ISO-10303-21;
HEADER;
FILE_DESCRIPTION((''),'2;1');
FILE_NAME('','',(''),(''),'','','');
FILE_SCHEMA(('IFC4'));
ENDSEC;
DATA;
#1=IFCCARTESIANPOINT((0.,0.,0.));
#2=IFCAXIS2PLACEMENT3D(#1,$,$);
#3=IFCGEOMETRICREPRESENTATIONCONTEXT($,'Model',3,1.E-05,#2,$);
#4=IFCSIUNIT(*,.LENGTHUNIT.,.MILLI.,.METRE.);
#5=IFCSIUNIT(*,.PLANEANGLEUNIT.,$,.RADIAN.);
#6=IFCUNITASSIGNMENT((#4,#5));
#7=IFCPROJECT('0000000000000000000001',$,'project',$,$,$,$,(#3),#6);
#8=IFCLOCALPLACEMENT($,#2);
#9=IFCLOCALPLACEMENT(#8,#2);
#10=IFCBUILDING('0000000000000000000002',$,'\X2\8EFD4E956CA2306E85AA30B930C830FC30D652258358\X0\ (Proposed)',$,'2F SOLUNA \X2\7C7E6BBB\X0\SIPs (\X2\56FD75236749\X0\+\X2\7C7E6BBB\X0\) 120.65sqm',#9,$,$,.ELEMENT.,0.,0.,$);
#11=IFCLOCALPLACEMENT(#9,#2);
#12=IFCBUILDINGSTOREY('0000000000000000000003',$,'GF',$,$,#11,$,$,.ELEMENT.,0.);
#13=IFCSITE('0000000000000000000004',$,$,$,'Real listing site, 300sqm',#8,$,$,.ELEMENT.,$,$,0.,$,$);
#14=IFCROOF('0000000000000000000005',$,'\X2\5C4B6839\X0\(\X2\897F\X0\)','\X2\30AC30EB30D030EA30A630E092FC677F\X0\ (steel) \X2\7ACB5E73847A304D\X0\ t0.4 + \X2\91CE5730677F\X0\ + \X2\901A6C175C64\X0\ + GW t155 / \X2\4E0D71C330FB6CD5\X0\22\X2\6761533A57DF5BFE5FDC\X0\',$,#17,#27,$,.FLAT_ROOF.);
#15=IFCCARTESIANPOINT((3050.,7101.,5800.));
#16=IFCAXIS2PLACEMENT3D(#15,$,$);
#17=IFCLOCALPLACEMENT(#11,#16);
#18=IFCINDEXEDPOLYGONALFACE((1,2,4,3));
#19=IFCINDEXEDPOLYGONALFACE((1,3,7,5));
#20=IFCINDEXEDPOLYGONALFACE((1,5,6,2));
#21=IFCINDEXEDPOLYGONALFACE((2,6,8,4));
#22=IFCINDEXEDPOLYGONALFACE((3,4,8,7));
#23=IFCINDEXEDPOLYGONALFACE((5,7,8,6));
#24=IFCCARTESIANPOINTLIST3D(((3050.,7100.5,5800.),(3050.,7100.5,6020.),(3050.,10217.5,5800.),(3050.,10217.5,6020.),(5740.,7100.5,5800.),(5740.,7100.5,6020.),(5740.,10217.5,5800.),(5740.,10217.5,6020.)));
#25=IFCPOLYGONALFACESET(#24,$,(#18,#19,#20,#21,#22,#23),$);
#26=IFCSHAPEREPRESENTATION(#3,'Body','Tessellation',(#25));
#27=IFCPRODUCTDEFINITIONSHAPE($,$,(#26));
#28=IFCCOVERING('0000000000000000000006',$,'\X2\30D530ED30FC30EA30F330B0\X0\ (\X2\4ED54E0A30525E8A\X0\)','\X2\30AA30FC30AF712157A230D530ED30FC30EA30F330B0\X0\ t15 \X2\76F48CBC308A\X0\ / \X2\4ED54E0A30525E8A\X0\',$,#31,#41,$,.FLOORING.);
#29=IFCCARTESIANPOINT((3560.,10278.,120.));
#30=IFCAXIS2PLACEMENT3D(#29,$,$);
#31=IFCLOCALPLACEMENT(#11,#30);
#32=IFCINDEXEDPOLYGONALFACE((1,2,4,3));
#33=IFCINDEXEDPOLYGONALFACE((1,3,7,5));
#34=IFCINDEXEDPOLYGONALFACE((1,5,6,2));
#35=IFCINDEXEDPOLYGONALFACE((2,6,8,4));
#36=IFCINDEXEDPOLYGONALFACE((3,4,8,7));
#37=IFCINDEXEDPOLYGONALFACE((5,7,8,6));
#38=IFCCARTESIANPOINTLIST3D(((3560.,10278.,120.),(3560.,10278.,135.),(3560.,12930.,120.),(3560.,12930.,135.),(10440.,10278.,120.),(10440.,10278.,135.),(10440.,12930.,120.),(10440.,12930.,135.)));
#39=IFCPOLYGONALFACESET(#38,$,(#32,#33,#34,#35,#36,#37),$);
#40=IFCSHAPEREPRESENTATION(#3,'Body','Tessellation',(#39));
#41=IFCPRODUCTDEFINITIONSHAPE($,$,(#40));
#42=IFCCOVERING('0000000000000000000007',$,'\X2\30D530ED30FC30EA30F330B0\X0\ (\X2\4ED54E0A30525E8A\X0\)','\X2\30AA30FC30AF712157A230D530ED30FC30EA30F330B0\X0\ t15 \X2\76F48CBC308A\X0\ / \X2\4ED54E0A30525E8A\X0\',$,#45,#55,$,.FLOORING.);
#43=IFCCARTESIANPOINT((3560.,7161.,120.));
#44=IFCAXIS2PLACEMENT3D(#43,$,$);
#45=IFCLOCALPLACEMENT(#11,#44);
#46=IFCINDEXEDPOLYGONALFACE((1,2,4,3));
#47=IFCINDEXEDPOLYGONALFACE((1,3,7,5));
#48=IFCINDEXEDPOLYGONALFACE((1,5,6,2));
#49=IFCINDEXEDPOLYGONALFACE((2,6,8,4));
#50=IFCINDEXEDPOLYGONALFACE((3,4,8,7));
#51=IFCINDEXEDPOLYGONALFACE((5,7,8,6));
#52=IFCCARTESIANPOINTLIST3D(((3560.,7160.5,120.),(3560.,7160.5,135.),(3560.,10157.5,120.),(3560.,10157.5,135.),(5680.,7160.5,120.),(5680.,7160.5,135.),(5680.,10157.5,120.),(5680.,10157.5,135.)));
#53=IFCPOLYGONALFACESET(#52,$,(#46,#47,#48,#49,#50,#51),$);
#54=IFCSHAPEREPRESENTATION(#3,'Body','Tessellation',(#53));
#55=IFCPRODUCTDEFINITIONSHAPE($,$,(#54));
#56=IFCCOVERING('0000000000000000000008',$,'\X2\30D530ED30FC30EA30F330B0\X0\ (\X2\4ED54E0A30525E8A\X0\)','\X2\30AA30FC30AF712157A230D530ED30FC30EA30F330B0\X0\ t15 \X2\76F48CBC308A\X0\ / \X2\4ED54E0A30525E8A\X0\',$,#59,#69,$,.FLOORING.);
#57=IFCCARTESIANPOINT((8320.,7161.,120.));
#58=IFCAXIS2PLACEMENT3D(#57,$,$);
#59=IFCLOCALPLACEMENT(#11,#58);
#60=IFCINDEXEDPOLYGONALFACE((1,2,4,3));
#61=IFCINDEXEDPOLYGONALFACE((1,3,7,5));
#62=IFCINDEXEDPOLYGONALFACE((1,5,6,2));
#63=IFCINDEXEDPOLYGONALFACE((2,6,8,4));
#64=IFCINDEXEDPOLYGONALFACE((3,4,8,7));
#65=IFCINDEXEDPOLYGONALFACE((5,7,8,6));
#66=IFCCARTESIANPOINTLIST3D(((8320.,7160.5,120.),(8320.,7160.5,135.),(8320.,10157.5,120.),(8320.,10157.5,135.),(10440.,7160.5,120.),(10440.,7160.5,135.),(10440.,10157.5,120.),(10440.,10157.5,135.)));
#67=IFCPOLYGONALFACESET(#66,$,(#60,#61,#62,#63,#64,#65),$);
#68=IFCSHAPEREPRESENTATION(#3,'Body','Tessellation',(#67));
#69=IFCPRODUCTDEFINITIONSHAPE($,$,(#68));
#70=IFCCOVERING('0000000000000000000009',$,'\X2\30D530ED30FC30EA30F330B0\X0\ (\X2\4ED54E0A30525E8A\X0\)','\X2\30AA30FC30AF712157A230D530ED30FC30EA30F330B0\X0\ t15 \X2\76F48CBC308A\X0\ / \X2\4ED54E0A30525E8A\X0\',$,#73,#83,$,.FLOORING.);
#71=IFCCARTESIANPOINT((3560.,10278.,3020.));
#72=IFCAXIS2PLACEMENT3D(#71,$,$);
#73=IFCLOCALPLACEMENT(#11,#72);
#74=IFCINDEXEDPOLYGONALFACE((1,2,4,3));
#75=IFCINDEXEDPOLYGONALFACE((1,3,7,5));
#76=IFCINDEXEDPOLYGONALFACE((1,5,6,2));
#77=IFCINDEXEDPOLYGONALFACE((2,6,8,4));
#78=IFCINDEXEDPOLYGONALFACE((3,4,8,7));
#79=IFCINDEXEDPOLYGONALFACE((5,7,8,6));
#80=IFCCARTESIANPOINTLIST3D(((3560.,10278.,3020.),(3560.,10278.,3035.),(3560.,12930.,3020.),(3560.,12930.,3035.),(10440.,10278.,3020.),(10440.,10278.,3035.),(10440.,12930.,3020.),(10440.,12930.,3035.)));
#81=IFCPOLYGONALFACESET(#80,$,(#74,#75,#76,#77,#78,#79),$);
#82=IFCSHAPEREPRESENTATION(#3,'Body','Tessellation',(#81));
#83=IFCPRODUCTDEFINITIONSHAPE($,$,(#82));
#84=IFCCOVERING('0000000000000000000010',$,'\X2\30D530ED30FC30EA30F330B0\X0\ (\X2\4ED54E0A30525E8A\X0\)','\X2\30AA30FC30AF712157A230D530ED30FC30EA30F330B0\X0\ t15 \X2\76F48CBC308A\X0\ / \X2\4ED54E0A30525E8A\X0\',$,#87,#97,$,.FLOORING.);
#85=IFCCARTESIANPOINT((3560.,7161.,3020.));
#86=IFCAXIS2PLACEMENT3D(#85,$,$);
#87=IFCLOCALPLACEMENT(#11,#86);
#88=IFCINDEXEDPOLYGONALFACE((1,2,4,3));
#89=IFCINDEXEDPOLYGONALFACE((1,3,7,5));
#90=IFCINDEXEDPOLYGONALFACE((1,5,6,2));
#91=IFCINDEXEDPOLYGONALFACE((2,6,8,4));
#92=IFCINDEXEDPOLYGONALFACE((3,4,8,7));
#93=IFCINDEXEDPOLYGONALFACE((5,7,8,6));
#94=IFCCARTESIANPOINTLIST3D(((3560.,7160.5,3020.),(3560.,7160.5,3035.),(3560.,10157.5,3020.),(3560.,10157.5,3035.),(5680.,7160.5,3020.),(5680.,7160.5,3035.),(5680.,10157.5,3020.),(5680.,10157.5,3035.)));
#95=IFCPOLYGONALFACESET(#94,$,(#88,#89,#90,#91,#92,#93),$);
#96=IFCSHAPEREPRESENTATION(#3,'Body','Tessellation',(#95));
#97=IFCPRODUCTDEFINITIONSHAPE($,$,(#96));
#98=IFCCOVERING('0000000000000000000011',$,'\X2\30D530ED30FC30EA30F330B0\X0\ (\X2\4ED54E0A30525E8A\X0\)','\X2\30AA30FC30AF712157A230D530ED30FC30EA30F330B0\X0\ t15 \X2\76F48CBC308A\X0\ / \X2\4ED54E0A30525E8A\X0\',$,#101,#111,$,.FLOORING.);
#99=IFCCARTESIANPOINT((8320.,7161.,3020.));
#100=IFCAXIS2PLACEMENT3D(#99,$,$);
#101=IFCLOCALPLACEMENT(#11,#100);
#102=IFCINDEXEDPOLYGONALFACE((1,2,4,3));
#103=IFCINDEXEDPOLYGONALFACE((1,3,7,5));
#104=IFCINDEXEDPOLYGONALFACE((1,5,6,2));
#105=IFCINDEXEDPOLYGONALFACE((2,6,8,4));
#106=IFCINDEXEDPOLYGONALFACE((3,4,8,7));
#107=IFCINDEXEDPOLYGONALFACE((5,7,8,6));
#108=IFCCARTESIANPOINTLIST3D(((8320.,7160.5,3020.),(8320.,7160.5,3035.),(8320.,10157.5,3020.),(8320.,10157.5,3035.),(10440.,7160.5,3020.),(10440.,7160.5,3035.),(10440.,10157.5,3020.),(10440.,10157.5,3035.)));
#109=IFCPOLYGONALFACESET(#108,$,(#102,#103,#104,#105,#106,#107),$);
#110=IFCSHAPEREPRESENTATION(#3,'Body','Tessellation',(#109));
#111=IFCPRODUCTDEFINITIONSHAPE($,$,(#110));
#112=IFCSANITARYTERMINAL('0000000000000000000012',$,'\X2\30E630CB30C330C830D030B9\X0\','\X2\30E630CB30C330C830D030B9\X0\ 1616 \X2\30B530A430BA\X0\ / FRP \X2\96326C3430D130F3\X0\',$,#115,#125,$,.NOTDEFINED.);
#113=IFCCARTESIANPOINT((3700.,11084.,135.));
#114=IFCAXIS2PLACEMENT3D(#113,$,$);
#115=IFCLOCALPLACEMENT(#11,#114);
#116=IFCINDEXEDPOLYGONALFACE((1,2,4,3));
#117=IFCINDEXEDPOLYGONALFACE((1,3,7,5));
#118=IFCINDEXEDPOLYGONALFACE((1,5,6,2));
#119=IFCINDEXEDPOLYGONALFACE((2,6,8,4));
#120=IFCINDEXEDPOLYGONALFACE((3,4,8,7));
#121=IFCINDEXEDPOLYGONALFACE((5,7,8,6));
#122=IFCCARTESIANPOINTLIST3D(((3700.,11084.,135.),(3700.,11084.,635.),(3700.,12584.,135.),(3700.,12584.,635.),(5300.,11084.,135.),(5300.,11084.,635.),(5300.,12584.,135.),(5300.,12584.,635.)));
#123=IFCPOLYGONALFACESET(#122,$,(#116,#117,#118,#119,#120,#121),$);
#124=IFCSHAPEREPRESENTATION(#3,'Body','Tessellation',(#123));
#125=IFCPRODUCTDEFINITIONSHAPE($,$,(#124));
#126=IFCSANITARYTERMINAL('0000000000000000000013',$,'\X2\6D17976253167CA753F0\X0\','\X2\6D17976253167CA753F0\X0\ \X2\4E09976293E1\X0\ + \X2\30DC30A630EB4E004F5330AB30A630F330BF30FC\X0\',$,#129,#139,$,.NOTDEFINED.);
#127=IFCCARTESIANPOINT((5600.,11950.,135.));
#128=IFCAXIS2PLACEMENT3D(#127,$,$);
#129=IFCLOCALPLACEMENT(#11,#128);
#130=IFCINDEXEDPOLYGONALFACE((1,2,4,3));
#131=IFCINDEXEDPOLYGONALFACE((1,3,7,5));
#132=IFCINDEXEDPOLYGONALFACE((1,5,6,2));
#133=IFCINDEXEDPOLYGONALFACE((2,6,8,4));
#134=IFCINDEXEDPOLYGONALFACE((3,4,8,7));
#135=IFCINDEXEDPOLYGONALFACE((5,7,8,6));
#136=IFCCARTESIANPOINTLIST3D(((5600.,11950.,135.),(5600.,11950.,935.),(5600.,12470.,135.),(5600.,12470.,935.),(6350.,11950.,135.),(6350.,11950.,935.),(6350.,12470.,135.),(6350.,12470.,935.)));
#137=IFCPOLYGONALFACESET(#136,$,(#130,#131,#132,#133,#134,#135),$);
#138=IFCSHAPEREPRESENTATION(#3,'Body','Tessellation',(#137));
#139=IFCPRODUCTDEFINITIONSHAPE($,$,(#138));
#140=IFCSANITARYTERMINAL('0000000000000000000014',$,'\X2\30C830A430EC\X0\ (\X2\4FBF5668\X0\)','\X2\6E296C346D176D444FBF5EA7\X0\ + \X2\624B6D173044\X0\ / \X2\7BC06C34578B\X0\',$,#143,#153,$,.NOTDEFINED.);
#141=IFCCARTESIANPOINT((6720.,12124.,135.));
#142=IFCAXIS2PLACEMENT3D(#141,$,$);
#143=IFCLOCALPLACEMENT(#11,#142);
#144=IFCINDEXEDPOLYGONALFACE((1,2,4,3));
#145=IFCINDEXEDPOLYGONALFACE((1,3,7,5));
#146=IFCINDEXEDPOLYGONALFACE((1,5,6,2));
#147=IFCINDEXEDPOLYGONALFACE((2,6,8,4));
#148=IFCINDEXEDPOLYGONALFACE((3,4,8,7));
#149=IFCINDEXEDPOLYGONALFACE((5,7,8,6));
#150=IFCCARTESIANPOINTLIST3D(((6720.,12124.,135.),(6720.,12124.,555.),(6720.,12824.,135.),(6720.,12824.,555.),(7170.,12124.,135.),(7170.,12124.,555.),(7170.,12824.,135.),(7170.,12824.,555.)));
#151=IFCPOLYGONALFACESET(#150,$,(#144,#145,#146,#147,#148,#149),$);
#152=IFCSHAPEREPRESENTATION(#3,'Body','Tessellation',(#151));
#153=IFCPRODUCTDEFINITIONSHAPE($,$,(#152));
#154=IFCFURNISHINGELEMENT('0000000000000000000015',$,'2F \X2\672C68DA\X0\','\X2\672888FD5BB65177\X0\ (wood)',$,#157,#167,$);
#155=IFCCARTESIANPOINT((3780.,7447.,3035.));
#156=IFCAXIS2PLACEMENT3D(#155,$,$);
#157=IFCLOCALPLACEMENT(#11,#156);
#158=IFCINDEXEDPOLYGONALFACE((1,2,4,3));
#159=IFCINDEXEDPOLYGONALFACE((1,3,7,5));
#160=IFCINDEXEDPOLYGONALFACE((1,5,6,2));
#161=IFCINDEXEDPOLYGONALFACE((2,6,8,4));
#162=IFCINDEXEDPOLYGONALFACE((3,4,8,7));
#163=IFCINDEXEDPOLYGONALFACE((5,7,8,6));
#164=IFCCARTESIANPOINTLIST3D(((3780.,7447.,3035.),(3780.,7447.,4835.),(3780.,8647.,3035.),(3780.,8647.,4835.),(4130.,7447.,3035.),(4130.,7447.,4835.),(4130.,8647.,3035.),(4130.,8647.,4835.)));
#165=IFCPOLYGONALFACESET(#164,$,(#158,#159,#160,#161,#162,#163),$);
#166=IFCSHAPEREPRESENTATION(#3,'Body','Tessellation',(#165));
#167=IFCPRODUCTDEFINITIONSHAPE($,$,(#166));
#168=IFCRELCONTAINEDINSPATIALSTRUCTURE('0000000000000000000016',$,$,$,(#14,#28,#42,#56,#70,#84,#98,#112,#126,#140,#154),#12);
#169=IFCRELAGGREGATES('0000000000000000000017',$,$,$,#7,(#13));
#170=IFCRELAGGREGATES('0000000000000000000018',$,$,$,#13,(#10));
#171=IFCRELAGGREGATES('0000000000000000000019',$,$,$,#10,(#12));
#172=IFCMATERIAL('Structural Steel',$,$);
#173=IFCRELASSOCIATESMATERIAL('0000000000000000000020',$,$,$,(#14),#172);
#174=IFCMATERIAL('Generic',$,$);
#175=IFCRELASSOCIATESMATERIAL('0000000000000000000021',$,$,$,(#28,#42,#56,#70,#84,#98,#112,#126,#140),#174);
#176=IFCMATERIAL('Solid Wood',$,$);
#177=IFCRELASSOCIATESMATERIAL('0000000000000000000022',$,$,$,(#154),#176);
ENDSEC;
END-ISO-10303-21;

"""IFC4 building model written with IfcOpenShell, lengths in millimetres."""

from ifc_helpers import new_model, si_unit, frame, frame_2d, origin, place, context, project, spatial, rectangle, extrude, material, element, save


model = new_model("IFC4")

# Units and contexts
model_context = context("Model", 3, precision=1e-05, world=origin())
ifc_project = project(units=[si_unit("LENGTHUNIT", "METRE", prefix="MILLI"), si_unit("PLANEANGLEUNIT", "RADIAN")], contexts=[model_context])

# Site, building, storey
site_placement = place(None, origin())
site = spatial("IfcSite", under=ifc_project, at=site_placement, ObjectType="Real listing site, 300sqm", CompositionType="ELEMENT", RefElevation=0.0)
building_placement = place(site_placement, origin())
building = spatial("IfcBuilding", under=site, at=building_placement, Name="軽井沢の薪ストーブ別荘 (Proposed)", ObjectType="2F SOLUNA 籾殻SIPs (国産杉+籾殻) 120.65sqm", CompositionType="ELEMENT", ElevationOfRefHeight=0.0, ElevationOfTerrain=0.0)
storey_placement = place(building_placement, origin())
storey = spatial("IfcBuildingStorey", under=building, at=storey_placement, Name="GF", CompositionType="ELEMENT", Elevation=0.0)

# Shared definitions
ifc_material_1 = material(Name="Solid Wood")

# Shared definitions
ifc_material_2 = material(Name="Generic")

# Roof
ifc_material_3 = material(Name="Structural Steel")
roof_1_placement = place(storey_placement, frame((3050.0, 7101.0, 5800.0)))
element("IfcRoof", 1, at=roof_1_placement, inside=storey, material=ifc_material_3, Name="屋根(西)", Description="ガルバリウム鋼板 (steel) 立平葺き t0.4 + 野地板 + 通気層 + GW t155 / 不燃・法22条区域対応", PredefinedType="FLAT_ROOF", context=model_context, shape_type="SweptSolid", body=[
    extrude(rectangle(XDim=2690.0, YDim=3117.0, at=frame_2d((1345.0, 1558.0))), frame((3050.0, 7101.0, 5800.0)), (0.0, 0.0, 1.0), 220.0),
])

# Coverings
covering_1_placement = place(storey_placement, frame((3560.0, 10278.0, 120.0)))
element("IfcCovering", 2, at=covering_1_placement, inside=storey, material=ifc_material_2, Name="フローリング (仕上げ床)", Description="オーク無垢フローリング t15 直貼り / 仕上げ床", PredefinedType="FLOORING", context=model_context, shape_type="SweptSolid", body=[
    extrude(rectangle(XDim=6880.0, YDim=2652.0, at=frame_2d((3440.0, 1326.0))), frame((3560.0, 10278.0, 120.0)), (0.0, 0.0, 1.0), 15.0),
])
covering_2_placement = place(storey_placement, frame((3560.0, 7161.0, 120.0)))
element("IfcCovering", 3, at=covering_2_placement, inside=storey, material=ifc_material_2, Name="フローリング (仕上げ床)", Description="オーク無垢フローリング t15 直貼り / 仕上げ床", PredefinedType="FLOORING", context=model_context, shape_type="SweptSolid", body=[
    extrude(rectangle(XDim=2120.0, YDim=2997.0, at=frame_2d((1060.0, 1498.0))), frame((3560.0, 7161.0, 120.0)), (0.0, 0.0, 1.0), 15.0),
])
covering_3_placement = place(storey_placement, frame((8320.0, 7161.0, 120.0)))
element("IfcCovering", 4, at=covering_3_placement, inside=storey, material=ifc_material_2, Name="フローリング (仕上げ床)", Description="オーク無垢フローリング t15 直貼り / 仕上げ床", PredefinedType="FLOORING", context=model_context, shape_type="SweptSolid", body=[
    extrude(rectangle(XDim=2120.0, YDim=2997.0, at=frame_2d((1060.0, 1498.0))), frame((8320.0, 7161.0, 120.0)), (0.0, 0.0, 1.0), 15.0),
])
covering_4_placement = place(storey_placement, frame((3560.0, 10278.0, 3020.0)))
element("IfcCovering", 5, at=covering_4_placement, inside=storey, material=ifc_material_2, Name="フローリング (仕上げ床)", Description="オーク無垢フローリング t15 直貼り / 仕上げ床", PredefinedType="FLOORING", context=model_context, shape_type="SweptSolid", body=[
    extrude(rectangle(XDim=6880.0, YDim=2652.0, at=frame_2d((3440.0, 1326.0))), frame((3560.0, 10278.0, 3020.0)), (0.0, 0.0, 1.0), 15.0),
])
covering_5_placement = place(storey_placement, frame((3560.0, 7161.0, 3020.0)))
element("IfcCovering", 6, at=covering_5_placement, inside=storey, material=ifc_material_2, Name="フローリング (仕上げ床)", Description="オーク無垢フローリング t15 直貼り / 仕上げ床", PredefinedType="FLOORING", context=model_context, shape_type="SweptSolid", body=[
    extrude(rectangle(XDim=2120.0, YDim=2997.0, at=frame_2d((1060.0, 1498.0))), frame((3560.0, 7161.0, 3020.0)), (0.0, 0.0, 1.0), 15.0),
])
covering_6_placement = place(storey_placement, frame((8320.0, 7161.0, 3020.0)))
element("IfcCovering", 7, at=covering_6_placement, inside=storey, material=ifc_material_2, Name="フローリング (仕上げ床)", Description="オーク無垢フローリング t15 直貼り / 仕上げ床", PredefinedType="FLOORING", context=model_context, shape_type="SweptSolid", body=[
    extrude(rectangle(XDim=2120.0, YDim=2997.0, at=frame_2d((1060.0, 1498.0))), frame((8320.0, 7161.0, 3020.0)), (0.0, 0.0, 1.0), 15.0),
])

# Sanitary terminals
sanitary_terminal_1_placement = place(storey_placement, frame((3700.0, 11084.0, 135.0)))
element("IfcSanitaryTerminal", 8, at=sanitary_terminal_1_placement, inside=storey, material=ifc_material_2, Name="ユニットバス", Description="ユニットバス 1616 サイズ / FRP 防水パン", PredefinedType="NOTDEFINED", context=model_context, shape_type="SweptSolid", body=[
    extrude(rectangle(XDim=1600.0, YDim=1500.0, at=frame_2d((800.0, 750.0))), frame((3700.0, 11084.0, 135.0)), (0.0, 0.0, 1.0), 500.0),
])
sanitary_terminal_2_placement = place(storey_placement, frame((5600.0, 11950.0, 135.0)))
element("IfcSanitaryTerminal", 9, at=sanitary_terminal_2_placement, inside=storey, material=ifc_material_2, Name="洗面化粧台", Description="洗面化粧台 三面鏡 + ボウル一体カウンター", PredefinedType="NOTDEFINED", context=model_context, shape_type="SweptSolid", body=[
    extrude(rectangle(XDim=750.0, YDim=520.0, at=frame_2d((375.0, 260.0))), frame((5600.0, 11950.0, 135.0)), (0.0, 0.0, 1.0), 800.0),
])
sanitary_terminal_3_placement = place(storey_placement, frame((6720.0, 12124.0, 135.0)))
element("IfcSanitaryTerminal", 10, at=sanitary_terminal_3_placement, inside=storey, material=ifc_material_2, Name="トイレ (便器)", Description="温水洗浄便座 + 手洗い / 節水型", PredefinedType="NOTDEFINED", context=model_context, shape_type="SweptSolid", body=[
    extrude(rectangle(XDim=450.0, YDim=700.0, at=frame_2d((225.0, 350.0))), frame((6720.0, 12124.0, 135.0)), (0.0, 0.0, 1.0), 420.0),
])

# Furnishing element
furnishing_placement = place(storey_placement, frame((3780.0, 7447.0, 3035.0)))
element("IfcFurnishingElement", 11, at=furnishing_placement, inside=storey, material=ifc_material_1, Name="2F 本棚", Description="木製家具 (wood)", context=model_context, shape_type="SweptSolid", body=[
    extrude(rectangle(XDim=350.0, YDim=1200.0, at=frame_2d((175.0, 600.0))), frame((3780.0, 7447.0, 3035.0)), (0.0, 0.0, 1.0), 1800.0),
])

save(model, "model.ifc")
